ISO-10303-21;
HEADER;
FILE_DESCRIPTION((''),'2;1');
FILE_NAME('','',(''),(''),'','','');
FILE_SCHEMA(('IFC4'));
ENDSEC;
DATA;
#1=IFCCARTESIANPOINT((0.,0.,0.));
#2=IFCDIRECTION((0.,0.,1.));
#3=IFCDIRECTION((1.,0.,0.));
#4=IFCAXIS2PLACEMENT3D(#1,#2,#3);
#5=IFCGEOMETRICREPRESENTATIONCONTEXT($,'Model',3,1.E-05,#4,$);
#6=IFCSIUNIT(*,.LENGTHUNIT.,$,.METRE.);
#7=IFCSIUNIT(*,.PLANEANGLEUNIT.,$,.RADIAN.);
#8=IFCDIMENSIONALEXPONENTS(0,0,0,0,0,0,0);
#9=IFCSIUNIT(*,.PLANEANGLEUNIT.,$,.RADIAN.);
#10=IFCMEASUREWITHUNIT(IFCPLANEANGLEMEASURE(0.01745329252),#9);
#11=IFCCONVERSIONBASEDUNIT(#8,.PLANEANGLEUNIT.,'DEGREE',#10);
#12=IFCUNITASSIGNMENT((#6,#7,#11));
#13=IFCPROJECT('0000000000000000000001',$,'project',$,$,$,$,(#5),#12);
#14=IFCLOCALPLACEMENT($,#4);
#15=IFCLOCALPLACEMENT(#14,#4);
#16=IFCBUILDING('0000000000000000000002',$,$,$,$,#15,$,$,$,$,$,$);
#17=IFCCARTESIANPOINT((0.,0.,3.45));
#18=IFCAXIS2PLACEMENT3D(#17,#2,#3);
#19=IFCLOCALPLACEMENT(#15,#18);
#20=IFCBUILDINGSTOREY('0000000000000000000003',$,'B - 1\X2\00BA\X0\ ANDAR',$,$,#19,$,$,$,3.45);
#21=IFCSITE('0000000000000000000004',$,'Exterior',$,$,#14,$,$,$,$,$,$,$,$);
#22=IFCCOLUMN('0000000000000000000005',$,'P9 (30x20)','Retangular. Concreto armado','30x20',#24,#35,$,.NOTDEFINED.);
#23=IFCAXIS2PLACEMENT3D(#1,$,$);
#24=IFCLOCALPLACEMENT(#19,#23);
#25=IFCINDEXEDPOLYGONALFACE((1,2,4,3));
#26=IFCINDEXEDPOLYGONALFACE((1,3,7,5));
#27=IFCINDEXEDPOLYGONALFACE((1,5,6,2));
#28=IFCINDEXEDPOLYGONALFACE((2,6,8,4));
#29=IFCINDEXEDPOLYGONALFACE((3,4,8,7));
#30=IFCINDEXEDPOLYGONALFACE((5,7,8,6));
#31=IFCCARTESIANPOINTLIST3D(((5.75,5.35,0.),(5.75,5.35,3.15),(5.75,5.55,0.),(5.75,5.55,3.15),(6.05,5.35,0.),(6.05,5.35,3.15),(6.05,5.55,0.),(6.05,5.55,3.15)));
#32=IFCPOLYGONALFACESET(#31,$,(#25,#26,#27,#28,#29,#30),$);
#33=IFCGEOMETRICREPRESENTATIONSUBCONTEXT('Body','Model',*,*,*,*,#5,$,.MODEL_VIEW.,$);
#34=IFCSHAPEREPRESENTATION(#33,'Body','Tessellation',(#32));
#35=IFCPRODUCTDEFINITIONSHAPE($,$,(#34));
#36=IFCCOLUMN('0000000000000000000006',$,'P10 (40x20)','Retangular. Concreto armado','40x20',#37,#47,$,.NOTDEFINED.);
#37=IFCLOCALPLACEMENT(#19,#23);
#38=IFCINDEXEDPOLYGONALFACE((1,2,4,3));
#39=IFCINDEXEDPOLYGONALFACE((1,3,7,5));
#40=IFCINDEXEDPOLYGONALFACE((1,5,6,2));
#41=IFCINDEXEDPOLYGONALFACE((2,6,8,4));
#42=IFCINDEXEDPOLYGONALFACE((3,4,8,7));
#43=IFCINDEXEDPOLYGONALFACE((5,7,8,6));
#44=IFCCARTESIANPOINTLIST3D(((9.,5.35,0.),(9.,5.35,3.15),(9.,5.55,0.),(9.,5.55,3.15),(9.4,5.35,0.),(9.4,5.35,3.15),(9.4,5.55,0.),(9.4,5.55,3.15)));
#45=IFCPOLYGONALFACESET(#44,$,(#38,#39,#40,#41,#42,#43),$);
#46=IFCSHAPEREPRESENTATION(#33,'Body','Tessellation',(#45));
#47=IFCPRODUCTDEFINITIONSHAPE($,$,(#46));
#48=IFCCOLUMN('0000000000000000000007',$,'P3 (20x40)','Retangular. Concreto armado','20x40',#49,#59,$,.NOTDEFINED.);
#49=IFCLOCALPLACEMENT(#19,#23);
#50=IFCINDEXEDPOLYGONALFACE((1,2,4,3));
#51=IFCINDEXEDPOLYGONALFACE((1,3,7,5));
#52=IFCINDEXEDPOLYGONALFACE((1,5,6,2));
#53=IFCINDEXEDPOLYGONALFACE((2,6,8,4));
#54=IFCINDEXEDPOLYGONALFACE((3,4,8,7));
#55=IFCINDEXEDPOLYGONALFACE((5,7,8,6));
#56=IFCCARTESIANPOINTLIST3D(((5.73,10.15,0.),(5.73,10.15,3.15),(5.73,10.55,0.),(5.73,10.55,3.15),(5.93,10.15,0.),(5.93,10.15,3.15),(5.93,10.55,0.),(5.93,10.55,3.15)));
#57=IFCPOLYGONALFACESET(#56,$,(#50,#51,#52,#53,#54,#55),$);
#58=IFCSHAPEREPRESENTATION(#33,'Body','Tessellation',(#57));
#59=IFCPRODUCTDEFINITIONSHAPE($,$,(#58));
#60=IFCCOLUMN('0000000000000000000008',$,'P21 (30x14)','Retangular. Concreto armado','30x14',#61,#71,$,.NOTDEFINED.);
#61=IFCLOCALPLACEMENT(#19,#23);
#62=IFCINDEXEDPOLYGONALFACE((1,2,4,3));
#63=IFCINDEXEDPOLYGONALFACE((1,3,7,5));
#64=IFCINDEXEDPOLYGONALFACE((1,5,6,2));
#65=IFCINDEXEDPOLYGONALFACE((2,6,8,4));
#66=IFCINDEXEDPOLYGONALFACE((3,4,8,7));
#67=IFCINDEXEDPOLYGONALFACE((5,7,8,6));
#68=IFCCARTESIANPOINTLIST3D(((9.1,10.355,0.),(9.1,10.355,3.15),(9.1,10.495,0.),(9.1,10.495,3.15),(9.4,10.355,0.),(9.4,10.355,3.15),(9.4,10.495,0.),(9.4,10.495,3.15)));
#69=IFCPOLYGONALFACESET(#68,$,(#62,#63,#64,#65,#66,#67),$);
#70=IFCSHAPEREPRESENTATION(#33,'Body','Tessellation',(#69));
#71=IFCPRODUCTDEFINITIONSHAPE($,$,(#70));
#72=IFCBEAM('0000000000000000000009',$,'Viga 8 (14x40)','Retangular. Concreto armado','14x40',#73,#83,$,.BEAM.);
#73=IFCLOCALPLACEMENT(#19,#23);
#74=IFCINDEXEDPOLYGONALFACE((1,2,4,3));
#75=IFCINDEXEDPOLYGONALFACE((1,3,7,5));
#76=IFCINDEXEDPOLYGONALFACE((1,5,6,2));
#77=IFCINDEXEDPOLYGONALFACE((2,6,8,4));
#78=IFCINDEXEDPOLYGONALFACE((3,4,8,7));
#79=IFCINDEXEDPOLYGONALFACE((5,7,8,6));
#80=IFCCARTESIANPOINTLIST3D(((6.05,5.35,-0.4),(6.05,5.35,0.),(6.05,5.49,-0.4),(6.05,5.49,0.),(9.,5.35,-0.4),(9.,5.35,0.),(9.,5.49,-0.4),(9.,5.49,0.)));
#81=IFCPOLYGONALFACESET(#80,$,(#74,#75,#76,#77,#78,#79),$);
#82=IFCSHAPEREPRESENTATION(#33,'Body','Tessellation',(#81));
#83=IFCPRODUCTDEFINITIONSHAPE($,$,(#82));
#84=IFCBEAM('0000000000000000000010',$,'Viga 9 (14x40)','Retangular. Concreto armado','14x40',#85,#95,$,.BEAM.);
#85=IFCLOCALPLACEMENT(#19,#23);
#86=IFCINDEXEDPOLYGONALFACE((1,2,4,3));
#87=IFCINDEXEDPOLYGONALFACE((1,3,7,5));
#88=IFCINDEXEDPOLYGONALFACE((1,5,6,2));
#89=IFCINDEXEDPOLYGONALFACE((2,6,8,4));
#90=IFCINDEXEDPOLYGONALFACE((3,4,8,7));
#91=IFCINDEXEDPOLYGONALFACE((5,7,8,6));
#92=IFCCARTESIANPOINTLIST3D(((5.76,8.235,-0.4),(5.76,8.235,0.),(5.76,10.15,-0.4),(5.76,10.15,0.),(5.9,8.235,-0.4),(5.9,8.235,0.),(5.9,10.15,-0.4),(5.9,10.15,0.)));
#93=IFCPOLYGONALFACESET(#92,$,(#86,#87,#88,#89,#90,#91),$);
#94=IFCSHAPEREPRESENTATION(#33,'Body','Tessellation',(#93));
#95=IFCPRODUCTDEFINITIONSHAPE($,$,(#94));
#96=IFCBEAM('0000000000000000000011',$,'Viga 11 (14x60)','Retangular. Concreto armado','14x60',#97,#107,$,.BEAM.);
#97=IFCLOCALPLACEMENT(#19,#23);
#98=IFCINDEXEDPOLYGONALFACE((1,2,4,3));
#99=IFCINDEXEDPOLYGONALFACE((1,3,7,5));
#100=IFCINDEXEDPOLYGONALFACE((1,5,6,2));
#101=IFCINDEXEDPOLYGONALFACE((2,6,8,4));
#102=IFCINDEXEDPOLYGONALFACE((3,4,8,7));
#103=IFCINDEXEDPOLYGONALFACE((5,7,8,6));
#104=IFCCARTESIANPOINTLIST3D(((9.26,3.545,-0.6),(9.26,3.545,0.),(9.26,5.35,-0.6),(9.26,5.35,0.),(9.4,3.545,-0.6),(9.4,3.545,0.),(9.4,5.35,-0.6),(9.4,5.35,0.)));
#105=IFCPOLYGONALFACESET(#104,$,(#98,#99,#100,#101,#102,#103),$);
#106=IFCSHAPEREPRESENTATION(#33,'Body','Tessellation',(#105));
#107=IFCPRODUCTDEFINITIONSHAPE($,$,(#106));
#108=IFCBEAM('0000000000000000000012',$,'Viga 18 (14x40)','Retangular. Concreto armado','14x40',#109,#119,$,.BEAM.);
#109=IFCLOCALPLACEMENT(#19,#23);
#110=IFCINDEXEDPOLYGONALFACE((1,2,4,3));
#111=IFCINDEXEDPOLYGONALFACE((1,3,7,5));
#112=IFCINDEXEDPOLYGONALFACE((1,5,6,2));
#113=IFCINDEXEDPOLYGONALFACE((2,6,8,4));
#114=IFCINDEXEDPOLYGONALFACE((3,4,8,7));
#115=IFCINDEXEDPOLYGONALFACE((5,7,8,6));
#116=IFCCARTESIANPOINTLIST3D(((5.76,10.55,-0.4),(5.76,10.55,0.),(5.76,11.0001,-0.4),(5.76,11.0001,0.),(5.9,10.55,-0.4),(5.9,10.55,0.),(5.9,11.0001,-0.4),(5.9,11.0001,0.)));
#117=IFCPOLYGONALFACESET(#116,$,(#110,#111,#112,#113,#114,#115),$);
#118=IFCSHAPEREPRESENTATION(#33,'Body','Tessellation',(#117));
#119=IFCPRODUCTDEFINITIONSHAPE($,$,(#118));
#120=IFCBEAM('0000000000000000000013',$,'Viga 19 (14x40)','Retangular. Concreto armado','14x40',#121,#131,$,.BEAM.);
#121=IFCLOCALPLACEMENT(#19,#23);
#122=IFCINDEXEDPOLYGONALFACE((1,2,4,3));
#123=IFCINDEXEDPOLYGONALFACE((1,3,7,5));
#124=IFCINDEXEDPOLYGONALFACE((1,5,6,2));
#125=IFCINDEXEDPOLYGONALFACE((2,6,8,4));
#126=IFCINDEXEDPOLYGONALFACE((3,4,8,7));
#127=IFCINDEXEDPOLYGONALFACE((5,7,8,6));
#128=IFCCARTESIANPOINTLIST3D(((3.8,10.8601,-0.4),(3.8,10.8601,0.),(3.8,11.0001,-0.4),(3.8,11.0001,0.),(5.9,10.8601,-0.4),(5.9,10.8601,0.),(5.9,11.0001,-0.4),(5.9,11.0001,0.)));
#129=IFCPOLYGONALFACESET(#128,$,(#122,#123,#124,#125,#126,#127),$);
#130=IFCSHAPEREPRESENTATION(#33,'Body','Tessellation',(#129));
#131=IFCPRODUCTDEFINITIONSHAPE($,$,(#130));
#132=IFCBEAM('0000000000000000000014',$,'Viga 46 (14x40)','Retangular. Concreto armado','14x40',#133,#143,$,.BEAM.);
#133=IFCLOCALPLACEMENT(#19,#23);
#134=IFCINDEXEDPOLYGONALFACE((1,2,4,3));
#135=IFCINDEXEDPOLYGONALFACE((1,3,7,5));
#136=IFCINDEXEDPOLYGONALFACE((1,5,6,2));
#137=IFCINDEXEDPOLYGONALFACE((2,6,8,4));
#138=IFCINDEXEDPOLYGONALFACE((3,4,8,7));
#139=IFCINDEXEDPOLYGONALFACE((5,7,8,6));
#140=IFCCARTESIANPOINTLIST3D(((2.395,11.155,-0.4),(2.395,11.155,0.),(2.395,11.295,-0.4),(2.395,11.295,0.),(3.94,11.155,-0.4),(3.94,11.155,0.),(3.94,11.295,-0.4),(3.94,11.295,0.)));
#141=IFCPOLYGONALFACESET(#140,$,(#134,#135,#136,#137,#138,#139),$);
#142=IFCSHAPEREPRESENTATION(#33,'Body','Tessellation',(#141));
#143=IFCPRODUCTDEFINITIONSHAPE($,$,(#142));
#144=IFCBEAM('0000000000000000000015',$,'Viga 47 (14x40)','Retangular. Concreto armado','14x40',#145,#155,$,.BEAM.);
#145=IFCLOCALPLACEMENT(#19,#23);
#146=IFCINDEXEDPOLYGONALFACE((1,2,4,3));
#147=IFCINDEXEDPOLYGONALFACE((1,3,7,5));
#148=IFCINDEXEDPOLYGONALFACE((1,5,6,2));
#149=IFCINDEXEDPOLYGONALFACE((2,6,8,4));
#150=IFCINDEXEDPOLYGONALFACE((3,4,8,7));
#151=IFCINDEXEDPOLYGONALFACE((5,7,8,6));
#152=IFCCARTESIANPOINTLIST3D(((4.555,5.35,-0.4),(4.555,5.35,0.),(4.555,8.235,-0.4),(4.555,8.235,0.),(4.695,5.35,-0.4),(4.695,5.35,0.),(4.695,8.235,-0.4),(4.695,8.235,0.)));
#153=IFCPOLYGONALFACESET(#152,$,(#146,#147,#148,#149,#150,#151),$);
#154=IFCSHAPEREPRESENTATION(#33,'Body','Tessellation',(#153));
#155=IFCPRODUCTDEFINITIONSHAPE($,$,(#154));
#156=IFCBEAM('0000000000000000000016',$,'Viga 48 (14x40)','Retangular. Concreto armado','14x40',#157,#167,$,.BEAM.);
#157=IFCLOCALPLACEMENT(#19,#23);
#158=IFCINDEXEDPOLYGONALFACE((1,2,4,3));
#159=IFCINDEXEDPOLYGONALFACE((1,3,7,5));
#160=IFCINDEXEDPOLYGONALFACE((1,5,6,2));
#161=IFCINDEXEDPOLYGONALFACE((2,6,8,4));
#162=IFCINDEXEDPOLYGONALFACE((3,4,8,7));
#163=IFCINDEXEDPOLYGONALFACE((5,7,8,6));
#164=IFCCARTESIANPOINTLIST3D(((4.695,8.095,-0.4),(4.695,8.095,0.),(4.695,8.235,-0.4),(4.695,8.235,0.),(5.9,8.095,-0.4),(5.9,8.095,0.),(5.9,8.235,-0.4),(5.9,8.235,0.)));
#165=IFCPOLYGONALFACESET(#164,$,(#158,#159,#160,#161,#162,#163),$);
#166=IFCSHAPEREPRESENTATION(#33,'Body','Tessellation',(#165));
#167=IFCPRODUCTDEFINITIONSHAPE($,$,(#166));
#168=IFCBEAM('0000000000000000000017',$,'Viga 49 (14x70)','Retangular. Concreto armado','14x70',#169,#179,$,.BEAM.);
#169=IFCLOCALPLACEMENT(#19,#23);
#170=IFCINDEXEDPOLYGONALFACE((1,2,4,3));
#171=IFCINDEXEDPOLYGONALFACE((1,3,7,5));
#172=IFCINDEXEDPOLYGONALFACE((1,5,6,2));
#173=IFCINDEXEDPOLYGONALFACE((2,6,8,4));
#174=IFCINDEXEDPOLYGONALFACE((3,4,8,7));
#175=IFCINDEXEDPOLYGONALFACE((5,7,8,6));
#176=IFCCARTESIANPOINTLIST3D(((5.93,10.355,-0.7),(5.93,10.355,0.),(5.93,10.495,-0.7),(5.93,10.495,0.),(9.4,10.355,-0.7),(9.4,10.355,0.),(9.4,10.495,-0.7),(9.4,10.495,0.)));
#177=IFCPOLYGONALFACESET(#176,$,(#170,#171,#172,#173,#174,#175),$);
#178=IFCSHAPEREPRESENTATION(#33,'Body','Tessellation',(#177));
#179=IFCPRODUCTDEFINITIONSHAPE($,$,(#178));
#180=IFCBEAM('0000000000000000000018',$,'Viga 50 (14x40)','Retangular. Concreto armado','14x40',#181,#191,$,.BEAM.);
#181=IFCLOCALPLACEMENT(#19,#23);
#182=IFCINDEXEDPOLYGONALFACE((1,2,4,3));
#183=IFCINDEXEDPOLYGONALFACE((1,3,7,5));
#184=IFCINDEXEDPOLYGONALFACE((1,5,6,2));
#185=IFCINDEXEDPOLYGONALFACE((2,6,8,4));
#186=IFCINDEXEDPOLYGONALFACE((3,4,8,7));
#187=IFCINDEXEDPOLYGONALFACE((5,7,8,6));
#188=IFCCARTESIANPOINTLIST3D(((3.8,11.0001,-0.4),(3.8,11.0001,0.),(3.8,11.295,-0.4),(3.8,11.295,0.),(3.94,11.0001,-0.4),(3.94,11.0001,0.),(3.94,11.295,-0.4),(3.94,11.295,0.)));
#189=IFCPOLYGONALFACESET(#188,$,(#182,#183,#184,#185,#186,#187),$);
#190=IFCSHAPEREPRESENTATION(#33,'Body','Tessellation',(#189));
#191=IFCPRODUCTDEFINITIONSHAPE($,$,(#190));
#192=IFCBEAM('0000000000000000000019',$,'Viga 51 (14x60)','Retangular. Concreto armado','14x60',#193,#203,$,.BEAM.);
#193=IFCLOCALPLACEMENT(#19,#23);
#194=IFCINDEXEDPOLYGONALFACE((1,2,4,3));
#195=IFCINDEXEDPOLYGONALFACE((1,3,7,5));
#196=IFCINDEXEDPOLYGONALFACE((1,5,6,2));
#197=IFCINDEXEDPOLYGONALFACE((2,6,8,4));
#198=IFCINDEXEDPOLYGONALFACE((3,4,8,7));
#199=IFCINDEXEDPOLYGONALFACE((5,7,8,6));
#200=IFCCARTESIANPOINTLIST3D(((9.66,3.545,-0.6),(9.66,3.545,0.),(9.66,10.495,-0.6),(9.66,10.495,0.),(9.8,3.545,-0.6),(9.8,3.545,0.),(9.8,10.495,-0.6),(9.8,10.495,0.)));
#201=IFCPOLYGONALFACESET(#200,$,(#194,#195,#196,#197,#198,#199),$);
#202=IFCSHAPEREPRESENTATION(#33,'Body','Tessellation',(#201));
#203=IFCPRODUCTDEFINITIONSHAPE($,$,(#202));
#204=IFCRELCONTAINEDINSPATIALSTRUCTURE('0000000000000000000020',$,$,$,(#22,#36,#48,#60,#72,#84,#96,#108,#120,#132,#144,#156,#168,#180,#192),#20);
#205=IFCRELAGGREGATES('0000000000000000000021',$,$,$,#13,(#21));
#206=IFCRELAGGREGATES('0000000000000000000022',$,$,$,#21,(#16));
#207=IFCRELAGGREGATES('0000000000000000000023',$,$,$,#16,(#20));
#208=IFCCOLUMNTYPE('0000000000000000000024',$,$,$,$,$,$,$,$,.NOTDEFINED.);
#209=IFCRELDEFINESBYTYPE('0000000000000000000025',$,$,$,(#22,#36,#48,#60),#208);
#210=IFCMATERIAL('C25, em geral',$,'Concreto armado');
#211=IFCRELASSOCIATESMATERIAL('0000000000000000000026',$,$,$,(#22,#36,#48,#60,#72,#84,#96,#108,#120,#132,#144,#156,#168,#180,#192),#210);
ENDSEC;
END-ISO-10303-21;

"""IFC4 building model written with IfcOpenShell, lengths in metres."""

from ifc_helpers import new_model, entity, si_unit, converted_unit, frame, frame_2d, origin_with_axes, origin_2d_with_axis, place, context, subcontext, project, spatial, rectangle, extrude, material, type_object, element, save


model = new_model("IFC4")

# Units and contexts
model_context = context("Model", 3, precision=1e-05, world=origin_with_axes())
body_context = subcontext(model_context, "Body", "Model", "MODEL_VIEW")
ifc_project = project(units=[si_unit("LENGTHUNIT", "METRE"), si_unit("PLANEANGLEUNIT", "RADIAN"), converted_unit("PLANEANGLEUNIT", "DEGREE", entity("IfcPlaneAngleMeasure", 0.01745329252), si_unit("PLANEANGLEUNIT", "RADIAN"), dimensions=[0, 0, 0, 0, 0, 0, 0])], contexts=[model_context])

# Site, building, storey
site_placement = place(None, origin_with_axes())
site = spatial("IfcSite", under=ifc_project, at=site_placement, Name="Exterior")
building_placement = place(site_placement, origin_with_axes())
building = spatial("IfcBuilding", under=site, at=building_placement)
storey_placement = place(building_placement, frame((0.0, 0.0, 3.45), z_axis=(0.0, 0.0, 1.0), x_axis=(1.0, 0.0, 0.0)))
storey = spatial("IfcBuildingStorey", under=building, at=storey_placement, Name="B - 1º ANDAR", Elevation=3.45)

# Columns
ifc_material = material(Name="C25, em geral", Category="Concreto armado")
column_type = type_object("IfcColumnType", PredefinedType="NOTDEFINED")
column_1_placement = place(storey_placement, frame((5.9, 5.45, 0.0), z_axis=(0.0, 0.0, 1.0), x_axis=(1.0, 0.0, 0.0)))
element("IfcColumn", 1, at=column_1_placement, inside=storey, type_object=column_type, material=ifc_material, Name="P9 (30x20)", Description="Retangular. Concreto armado", ObjectType="30x20", PredefinedType="NOTDEFINED", context=body_context, shape_type="SweptSolid", body=[
    extrude(rectangle(XDim=0.3, YDim=0.2, at=origin_2d_with_axis()), origin_with_axes(), (0.0, 0.0, 1.0), 3.15),
])
column_2_placement = place(storey_placement, frame((9.2, 5.45, 0.0), z_axis=(0.0, 0.0, 1.0), x_axis=(1.0, 0.0, 0.0)))
element("IfcColumn", 2, at=column_2_placement, inside=storey, type_object=column_type, material=ifc_material, Name="P10 (40x20)", Description="Retangular. Concreto armado", ObjectType="40x20", PredefinedType="NOTDEFINED", context=body_context, shape_type="SweptSolid", body=[
    extrude(rectangle(XDim=0.4, YDim=0.2, at=origin_2d_with_axis()), origin_with_axes(), (0.0, 0.0, 1.0), 3.15),
])
column_3_placement = place(storey_placement, frame((5.83, 10.35, 0.0), z_axis=(0.0, 0.0, 1.0), x_axis=(1.0, 0.0, 0.0)))
element("IfcColumn", 3, at=column_3_placement, inside=storey, type_object=column_type, material=ifc_material, Name="P3 (20x40)", Description="Retangular. Concreto armado", ObjectType="20x40", PredefinedType="NOTDEFINED", context=body_context, shape_type="SweptSolid", body=[
    extrude(rectangle(XDim=0.2, YDim=0.4, at=origin_2d_with_axis()), origin_with_axes(), (0.0, 0.0, 1.0), 3.15),
])
column_4_placement = place(storey_placement, frame((9.25, 10.425, 0.0), z_axis=(0.0, 0.0, 1.0), x_axis=(1.0, 0.0, 0.0)))
element("IfcColumn", 4, at=column_4_placement, inside=storey, type_object=column_type, material=ifc_material, Name="P21 (30x14)", Description="Retangular. Concreto armado", ObjectType="30x14", PredefinedType="NOTDEFINED", context=body_context, shape_type="SweptSolid", body=[
    extrude(rectangle(XDim=0.3, YDim=0.14, at=origin_2d_with_axis()), origin_with_axes(), (0.0, 0.0, 1.0), 3.15),
])

# Beams
beam_1_placement = place(storey_placement, frame((9.0, 5.42, 0.0), z_axis=(-1.0, 0.0, 0.0), x_axis=(0.0, -1.0, 0.0)))
element("IfcBeam", 5, at=beam_1_placement, inside=storey, material=ifc_material, Name="Viga 8 (14x40)", Description="Retangular. Concreto armado", ObjectType="14x40", PredefinedType="BEAM", context=body_context, shape_type="SweptSolid", body=[
    extrude(rectangle(XDim=0.14, YDim=0.4, at=frame_2d((0.0, -0.2), x_axis=(1.0, 0.0))), origin_with_axes(), (0.0, 0.0, 1.0), 2.95),
])
beam_2_placement = place(storey_placement, frame((5.83, 10.15, 0.0), z_axis=(0.0, -1.0, 0.0), x_axis=(1.0, 0.0, 0.0)))
element("IfcBeam", 6, at=beam_2_placement, inside=storey, material=ifc_material, Name="Viga 9 (14x40)", Description="Retangular. Concreto armado", ObjectType="14x40", PredefinedType="BEAM", context=body_context, shape_type="SweptSolid", body=[
    extrude(rectangle(XDim=0.14, YDim=0.4, at=frame_2d((0.0, -0.2), x_axis=(1.0, 0.0))), origin_with_axes(), (0.0, 0.0, 1.0), 1.915),
])
beam_3_placement = place(storey_placement, frame((9.33, 5.35, 0.0), z_axis=(0.0, -1.0, 0.0), x_axis=(1.0, 0.0, 0.0)))
element("IfcBeam", 7, at=beam_3_placement, inside=storey, material=ifc_material, Name="Viga 11 (14x60)", Description="Retangular. Concreto armado", ObjectType="14x60", PredefinedType="BEAM", context=body_context, shape_type="SweptSolid", body=[
    extrude(rectangle(XDim=0.14, YDim=0.6, at=frame_2d((0.0, -0.3), x_axis=(1.0, 0.0))), origin_with_axes(), (0.0, 0.0, 1.0), 1.805),
])
beam_4_placement = place(storey_placement, frame((5.83, 10.55, 0.0), z_axis=(0.0, 1.0, 0.0), x_axis=(-1.0, 0.0, 0.0)))
element("IfcBeam", 8, at=beam_4_placement, inside=storey, material=ifc_material, Name="Viga 18 (14x40)", Description="Retangular. Concreto armado", ObjectType="14x40", PredefinedType="BEAM", context=body_context, shape_type="SweptSolid", body=[
    extrude(rectangle(XDim=0.14, YDim=0.4, at=frame_2d((0.0, -0.2), x_axis=(1.0, 0.0))), origin_with_axes(), (0.0, 0.0, 1.0), 0.4501),
])
beam_5_placement = place(storey_placement, frame((3.8, 10.9301, 0.0), z_axis=(1.0, 0.0, 0.0), x_axis=(0.0, 1.0, 0.0)))
element("IfcBeam", 9, at=beam_5_placement, inside=storey, material=ifc_material, Name="Viga 19 (14x40)", Description="Retangular. Concreto armado", ObjectType="14x40", PredefinedType="BEAM", context=body_context, shape_type="SweptSolid", body=[
    extrude(rectangle(XDim=0.14, YDim=0.4, at=frame_2d((0.0, -0.2), x_axis=(1.0, 0.0))), origin_with_axes(), (0.0, 0.0, 1.0), 2.1),
])
beam_6_placement = place(storey_placement, frame((2.395, 11.225, 0.0), z_axis=(1.0, 0.0, 0.0), x_axis=(0.0, 1.0, 0.0)))
element("IfcBeam", 10, at=beam_6_placement, inside=storey, material=ifc_material, Name="Viga 46 (14x40)", Description="Retangular. Concreto armado", ObjectType="14x40", PredefinedType="BEAM", context=body_context, shape_type="SweptSolid", body=[
    extrude(rectangle(XDim=0.14, YDim=0.4, at=frame_2d((0.0, -0.2), x_axis=(1.0, 0.0))), origin_with_axes(), (0.0, 0.0, 1.0), 1.545),
])
beam_7_placement = place(storey_placement, frame((4.625, 5.35, 0.0), z_axis=(0.0, 1.0, 0.0), x_axis=(-1.0, 0.0, 0.0)))
element("IfcBeam", 11, at=beam_7_placement, inside=storey, material=ifc_material, Name="Viga 47 (14x40)", Description="Retangular. Concreto armado", ObjectType="14x40", PredefinedType="BEAM", context=body_context, shape_type="SweptSolid", body=[
    extrude(rectangle(XDim=0.14, YDim=0.4, at=frame_2d((0.0, -0.2), x_axis=(1.0, 0.0))), origin_with_axes(), (0.0, 0.0, 1.0), 2.885),
])
beam_8_placement = place(storey_placement, frame((5.9, 8.165, 0.0), z_axis=(-1.0, 0.0, 0.0), x_axis=(0.0, -1.0, 0.0)))
element("IfcBeam", 12, at=beam_8_placement, inside=storey, material=ifc_material, Name="Viga 48 (14x40)", Description="Retangular. Concreto armado", ObjectType="14x40", PredefinedType="BEAM", context=body_context, shape_type="SweptSolid", body=[
    extrude(rectangle(XDim=0.14, YDim=0.4, at=frame_2d((0.0, -0.2), x_axis=(1.0, 0.0))), origin_with_axes(), (0.0, 0.0, 1.0), 1.205),
])
beam_9_placement = place(storey_placement, frame((5.93, 10.425, 0.0), z_axis=(1.0, 0.0, 0.0), x_axis=(0.0, 1.0, 0.0)))
element("IfcBeam", 13, at=beam_9_placement, inside=storey, material=ifc_material, Name="Viga 49 (14x70)", Description="Retangular. Concreto armado", ObjectType="14x70", PredefinedType="BEAM", context=body_context, shape_type="SweptSolid", body=[
    extrude(rectangle(XDim=0.14, YDim=0.7, at=frame_2d((0.0, -0.35), x_axis=(1.0, 0.0))), origin_with_axes(), (0.0, 0.0, 1.0), 3.47),
])
beam_10_placement = place(storey_placement, frame((3.87, 11.0001, 0.0), z_axis=(0.0, 1.0, 0.0), x_axis=(-1.0, 0.0, 0.0)))
element("IfcBeam", 14, at=beam_10_placement, inside=storey, material=ifc_material, Name="Viga 50 (14x40)", Description="Retangular. Concreto armado", ObjectType="14x40", PredefinedType="BEAM", context=body_context, shape_type="SweptSolid", body=[
    extrude(rectangle(XDim=0.14, YDim=0.4, at=frame_2d((0.0, -0.2), x_axis=(1.0, 0.0))), origin_with_axes(), (0.0, 0.0, 1.0), 0.2949),
])
beam_11_placement = place(storey_placement, frame((9.73, 10.495, 0.0), z_axis=(0.0, -1.0, 0.0), x_axis=(1.0, 0.0, 0.0)))
element("IfcBeam", 15, at=beam_11_placement, inside=storey, material=ifc_material, Name="Viga 51 (14x60)", Description="Retangular. Concreto armado", ObjectType="14x60", PredefinedType="BEAM", context=body_context, shape_type="SweptSolid", body=[
    extrude(rectangle(XDim=0.14, YDim=0.6, at=frame_2d((0.0, -0.3), x_axis=(1.0, 0.0))), origin_with_axes(), (0.0, 0.0, 1.0), 6.95),
])

save(model, "model.ifc")
